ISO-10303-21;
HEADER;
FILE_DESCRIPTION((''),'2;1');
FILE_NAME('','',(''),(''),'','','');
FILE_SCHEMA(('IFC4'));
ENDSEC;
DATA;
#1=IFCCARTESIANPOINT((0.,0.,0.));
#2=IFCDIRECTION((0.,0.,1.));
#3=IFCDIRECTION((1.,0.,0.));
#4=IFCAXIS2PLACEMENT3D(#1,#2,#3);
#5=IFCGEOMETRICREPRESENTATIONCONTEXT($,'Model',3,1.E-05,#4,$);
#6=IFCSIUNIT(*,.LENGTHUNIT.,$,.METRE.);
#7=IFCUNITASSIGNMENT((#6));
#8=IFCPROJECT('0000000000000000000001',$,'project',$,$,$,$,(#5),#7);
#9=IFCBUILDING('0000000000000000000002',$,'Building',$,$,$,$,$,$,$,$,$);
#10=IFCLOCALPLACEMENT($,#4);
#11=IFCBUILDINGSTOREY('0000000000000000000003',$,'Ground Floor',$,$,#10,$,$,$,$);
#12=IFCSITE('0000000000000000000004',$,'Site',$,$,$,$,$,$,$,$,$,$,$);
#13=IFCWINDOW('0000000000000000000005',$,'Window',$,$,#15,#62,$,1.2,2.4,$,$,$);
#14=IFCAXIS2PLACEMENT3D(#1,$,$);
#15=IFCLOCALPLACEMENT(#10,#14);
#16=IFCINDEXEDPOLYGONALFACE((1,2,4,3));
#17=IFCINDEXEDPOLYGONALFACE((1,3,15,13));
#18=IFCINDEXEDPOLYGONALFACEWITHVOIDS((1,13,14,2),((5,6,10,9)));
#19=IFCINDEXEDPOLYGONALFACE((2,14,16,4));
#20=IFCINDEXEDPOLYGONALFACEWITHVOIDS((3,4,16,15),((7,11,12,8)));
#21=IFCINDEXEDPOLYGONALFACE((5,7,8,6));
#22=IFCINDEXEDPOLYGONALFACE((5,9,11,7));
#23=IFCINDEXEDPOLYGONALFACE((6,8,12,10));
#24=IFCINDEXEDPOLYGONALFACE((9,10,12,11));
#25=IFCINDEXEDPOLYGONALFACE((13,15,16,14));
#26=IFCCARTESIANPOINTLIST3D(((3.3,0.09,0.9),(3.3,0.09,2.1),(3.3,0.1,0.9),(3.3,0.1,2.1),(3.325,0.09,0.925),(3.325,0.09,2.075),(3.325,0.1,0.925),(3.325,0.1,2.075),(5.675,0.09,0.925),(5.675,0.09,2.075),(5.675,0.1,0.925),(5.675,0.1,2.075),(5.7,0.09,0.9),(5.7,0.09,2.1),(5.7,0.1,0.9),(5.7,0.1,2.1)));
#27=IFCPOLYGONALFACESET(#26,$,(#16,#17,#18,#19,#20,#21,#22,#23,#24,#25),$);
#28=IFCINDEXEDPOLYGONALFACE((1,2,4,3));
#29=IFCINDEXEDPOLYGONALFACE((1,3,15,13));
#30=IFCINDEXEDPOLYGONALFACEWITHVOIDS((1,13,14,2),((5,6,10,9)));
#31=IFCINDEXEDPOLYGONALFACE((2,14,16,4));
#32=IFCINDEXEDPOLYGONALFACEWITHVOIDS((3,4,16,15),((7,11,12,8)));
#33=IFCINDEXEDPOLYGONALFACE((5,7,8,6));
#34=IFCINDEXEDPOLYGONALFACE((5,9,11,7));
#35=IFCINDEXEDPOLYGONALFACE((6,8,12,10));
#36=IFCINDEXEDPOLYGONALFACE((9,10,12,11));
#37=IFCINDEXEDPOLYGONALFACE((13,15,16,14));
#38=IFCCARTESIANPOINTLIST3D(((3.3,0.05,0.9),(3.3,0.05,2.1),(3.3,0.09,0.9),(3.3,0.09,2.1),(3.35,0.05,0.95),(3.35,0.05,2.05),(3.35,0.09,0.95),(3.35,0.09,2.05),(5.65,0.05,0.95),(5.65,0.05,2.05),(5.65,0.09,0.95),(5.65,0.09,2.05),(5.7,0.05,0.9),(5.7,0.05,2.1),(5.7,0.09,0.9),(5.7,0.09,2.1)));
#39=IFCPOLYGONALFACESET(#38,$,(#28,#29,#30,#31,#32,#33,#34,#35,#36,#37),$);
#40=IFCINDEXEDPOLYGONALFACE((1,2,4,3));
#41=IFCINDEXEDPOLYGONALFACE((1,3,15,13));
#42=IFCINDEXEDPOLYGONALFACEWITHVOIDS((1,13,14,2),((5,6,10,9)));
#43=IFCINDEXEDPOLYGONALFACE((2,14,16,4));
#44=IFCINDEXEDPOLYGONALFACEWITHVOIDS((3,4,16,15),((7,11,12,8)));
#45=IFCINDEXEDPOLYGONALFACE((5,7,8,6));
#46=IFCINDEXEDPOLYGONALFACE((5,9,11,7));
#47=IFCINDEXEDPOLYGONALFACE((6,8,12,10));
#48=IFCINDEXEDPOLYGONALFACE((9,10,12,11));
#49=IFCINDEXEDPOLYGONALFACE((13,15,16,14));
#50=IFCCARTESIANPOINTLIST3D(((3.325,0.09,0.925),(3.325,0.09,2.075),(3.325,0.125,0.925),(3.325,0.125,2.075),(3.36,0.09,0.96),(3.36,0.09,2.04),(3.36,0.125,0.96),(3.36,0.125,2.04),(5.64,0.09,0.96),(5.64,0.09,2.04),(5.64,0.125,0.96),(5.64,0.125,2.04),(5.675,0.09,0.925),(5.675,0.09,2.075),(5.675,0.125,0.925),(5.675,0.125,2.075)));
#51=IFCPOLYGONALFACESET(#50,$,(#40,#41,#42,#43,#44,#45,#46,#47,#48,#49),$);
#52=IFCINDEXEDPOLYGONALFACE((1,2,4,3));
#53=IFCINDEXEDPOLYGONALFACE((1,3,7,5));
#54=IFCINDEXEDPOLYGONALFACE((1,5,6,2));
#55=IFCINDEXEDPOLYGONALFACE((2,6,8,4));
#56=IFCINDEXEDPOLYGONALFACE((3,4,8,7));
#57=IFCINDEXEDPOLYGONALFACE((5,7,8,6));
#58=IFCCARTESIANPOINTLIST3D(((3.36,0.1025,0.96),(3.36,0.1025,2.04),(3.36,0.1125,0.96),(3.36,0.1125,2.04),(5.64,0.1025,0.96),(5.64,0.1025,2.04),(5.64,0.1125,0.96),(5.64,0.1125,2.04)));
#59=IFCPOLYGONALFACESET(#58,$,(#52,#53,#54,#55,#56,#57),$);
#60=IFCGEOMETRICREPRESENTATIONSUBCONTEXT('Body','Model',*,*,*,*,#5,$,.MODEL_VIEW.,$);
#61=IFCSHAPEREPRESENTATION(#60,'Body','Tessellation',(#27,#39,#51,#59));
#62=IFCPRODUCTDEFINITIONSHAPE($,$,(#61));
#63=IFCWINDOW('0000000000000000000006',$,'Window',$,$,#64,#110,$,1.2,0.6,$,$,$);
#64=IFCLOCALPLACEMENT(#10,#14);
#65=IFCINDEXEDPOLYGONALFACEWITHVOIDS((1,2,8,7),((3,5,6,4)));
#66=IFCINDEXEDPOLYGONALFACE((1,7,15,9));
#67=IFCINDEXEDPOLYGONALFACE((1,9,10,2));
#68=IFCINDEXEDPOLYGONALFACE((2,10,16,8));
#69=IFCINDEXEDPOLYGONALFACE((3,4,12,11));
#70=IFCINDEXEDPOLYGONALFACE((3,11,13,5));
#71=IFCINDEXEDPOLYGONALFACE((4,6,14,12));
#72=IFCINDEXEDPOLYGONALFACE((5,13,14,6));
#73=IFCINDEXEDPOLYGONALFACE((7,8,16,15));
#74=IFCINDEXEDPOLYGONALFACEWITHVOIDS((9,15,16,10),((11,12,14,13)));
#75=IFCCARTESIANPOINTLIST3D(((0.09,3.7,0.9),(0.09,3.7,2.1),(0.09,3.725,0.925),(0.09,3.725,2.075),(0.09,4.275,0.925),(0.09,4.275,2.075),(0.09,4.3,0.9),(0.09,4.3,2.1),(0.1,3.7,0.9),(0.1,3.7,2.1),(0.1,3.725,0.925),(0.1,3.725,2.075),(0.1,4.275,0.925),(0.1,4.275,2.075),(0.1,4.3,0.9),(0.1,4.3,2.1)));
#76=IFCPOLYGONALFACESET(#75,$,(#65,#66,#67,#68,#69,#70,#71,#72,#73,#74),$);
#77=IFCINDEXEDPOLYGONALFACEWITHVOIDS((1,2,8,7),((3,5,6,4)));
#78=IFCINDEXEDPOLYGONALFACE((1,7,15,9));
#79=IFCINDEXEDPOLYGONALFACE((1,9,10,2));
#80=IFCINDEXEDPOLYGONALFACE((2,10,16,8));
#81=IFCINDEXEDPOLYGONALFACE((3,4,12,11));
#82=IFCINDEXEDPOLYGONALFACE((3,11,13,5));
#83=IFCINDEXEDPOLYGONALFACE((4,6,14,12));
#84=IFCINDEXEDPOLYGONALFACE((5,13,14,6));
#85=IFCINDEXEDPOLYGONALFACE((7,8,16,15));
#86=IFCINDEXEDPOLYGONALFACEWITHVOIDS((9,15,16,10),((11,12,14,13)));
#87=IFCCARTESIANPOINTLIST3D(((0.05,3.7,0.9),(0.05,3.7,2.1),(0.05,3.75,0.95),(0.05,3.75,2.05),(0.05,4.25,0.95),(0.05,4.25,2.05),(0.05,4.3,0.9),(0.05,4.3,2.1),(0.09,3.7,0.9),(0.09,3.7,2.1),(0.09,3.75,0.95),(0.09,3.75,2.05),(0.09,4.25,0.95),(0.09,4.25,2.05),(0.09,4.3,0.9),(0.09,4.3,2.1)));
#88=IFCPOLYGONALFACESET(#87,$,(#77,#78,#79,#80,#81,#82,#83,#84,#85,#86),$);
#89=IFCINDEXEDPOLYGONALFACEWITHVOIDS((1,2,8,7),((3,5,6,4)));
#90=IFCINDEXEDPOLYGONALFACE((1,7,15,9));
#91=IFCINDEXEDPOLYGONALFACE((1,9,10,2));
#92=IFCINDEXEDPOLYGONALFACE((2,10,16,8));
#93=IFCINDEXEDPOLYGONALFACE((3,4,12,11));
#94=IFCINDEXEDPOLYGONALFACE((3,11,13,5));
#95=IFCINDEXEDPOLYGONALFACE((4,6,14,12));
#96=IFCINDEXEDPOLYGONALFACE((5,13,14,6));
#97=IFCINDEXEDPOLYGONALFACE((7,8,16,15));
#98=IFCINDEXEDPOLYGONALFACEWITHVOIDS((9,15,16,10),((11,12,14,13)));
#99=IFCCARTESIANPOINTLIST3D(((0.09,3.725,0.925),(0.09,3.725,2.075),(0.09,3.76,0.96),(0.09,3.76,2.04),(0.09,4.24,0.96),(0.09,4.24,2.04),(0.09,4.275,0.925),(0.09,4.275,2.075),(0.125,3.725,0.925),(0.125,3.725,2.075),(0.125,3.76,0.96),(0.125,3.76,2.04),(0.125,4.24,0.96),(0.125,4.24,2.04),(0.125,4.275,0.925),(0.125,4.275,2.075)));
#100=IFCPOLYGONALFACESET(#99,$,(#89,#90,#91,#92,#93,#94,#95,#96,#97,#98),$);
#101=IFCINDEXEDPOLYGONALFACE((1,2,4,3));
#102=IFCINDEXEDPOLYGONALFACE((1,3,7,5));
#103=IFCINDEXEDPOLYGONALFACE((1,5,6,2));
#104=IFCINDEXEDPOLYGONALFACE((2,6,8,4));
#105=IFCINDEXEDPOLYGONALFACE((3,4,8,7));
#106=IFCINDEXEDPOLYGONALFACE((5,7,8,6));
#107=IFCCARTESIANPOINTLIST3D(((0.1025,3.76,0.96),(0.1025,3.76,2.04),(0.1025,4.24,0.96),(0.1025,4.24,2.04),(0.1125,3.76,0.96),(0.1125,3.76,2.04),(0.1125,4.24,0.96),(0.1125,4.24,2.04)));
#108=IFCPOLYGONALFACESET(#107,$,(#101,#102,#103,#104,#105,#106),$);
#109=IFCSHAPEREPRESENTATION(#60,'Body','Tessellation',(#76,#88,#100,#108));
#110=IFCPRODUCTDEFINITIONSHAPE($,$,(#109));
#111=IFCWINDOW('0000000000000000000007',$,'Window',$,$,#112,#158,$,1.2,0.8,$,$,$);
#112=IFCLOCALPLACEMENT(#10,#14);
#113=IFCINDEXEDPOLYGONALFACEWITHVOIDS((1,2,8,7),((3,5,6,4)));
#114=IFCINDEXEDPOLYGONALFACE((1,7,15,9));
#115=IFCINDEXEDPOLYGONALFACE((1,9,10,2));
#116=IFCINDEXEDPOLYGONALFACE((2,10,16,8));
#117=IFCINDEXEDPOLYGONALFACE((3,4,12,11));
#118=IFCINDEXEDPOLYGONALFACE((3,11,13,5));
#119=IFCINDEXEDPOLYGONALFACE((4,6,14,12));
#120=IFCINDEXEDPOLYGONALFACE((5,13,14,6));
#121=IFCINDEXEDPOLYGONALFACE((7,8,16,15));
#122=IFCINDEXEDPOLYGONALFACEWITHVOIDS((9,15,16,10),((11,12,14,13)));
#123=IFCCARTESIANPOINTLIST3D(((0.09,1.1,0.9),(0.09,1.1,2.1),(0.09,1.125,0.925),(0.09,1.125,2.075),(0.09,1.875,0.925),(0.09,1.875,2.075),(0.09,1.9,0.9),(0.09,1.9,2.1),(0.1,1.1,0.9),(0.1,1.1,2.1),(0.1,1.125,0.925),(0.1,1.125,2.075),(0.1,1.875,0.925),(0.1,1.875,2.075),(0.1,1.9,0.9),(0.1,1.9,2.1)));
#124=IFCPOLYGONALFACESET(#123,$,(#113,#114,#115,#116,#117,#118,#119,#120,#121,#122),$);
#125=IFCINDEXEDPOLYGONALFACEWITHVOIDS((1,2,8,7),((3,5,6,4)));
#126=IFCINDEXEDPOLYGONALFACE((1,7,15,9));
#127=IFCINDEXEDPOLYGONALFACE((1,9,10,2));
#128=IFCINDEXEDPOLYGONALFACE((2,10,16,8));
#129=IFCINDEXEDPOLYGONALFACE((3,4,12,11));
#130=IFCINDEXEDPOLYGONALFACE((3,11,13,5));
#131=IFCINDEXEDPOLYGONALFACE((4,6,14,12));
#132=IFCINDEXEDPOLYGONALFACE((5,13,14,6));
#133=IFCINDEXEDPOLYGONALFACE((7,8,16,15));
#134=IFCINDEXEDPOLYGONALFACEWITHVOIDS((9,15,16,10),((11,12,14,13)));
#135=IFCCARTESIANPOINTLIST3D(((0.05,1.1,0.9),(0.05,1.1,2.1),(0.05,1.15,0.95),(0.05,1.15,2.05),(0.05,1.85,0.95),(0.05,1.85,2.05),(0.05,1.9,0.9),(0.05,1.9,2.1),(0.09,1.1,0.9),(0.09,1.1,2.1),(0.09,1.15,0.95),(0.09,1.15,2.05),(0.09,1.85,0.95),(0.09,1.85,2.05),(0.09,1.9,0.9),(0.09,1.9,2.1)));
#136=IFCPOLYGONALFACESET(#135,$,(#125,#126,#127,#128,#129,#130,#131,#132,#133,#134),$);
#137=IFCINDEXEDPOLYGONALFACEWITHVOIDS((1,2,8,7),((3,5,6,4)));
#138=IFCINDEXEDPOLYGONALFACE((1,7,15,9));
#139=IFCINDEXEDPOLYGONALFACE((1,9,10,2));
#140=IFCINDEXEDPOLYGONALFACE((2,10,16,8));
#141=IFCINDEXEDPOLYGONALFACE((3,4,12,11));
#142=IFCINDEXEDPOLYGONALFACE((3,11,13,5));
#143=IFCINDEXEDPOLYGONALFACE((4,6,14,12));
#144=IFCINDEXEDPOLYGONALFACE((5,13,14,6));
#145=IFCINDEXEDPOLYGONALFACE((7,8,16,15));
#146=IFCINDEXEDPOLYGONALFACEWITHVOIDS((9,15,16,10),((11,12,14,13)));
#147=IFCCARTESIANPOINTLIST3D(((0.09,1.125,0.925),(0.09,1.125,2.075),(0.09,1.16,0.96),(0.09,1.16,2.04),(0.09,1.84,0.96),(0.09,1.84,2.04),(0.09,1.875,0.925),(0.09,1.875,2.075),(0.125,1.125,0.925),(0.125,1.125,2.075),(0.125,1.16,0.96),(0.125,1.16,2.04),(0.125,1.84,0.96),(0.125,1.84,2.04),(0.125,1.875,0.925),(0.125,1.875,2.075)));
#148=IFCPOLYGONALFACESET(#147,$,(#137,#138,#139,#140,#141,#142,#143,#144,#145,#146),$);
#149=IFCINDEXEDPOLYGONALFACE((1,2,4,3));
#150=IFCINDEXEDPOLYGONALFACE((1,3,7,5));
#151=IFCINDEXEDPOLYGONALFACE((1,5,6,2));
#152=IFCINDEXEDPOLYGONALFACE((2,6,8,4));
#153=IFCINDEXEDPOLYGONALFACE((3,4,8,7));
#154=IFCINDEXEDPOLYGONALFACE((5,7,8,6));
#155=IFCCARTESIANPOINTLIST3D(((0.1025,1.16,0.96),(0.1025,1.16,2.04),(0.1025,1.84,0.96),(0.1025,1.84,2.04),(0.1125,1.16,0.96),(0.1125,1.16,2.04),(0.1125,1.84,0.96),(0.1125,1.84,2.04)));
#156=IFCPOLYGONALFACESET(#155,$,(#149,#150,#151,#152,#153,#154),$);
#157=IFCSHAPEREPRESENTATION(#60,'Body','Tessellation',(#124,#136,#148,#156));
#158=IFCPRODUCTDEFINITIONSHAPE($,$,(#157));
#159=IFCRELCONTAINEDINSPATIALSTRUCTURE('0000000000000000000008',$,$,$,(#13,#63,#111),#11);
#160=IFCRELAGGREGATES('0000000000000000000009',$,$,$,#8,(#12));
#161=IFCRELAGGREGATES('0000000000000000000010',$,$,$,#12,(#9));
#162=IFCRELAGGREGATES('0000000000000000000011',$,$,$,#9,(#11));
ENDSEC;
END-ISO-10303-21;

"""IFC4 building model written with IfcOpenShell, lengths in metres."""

from ifc_helpers import new_model, si_unit, frame, origin_with_axes, place, context, subcontext, project, spatial, line, indexed_curve, outline, extrude, element, save


model = new_model("IFC4")

# Units and contexts
model_context = context("Model", 3, precision=1e-05, world=origin_with_axes())
body_context = subcontext(model_context, "Body", "Model", "MODEL_VIEW")
ifc_project = project(units=[si_unit("LENGTHUNIT", "METRE")], contexts=[model_context])

# Site, building, storey
site = spatial("IfcSite", under=ifc_project, Name="Site")
building = spatial("IfcBuilding", under=site, Name="Building")
storey_placement = place(None, origin_with_axes())
storey = spatial("IfcBuildingStorey", under=building, at=storey_placement, Name="Ground Floor")

# Windows
window_1_placement = place(storey_placement, frame((3.3, 0.0, 0.9), z_axis=(0.0, 0.0, 1.0), x_axis=(1.0, 0.0, 0.0)))
element("IfcWindow", 1, at=window_1_placement, inside=storey, Name="Window", OverallHeight=1.2, OverallWidth=2.4, context=body_context, shape_type="SweptSolid", body=[
    extrude(outline(indexed_curve([(0.0, 0.0), (2.4, 0.0), (2.4, 1.2), (0.0, 1.2)], segments=[line(1, 2, 3, 4, 1)]), holes=[indexed_curve([(0.025, 0.025), (2.375, 0.025), (2.375, 1.175), (0.025, 1.175)], segments=[line(1, 2, 3, 4, 1)])]), frame((0.0, 0.09, 0.0), z_axis=(0.0, -1.0, 0.0), x_axis=(1.0, 0.0, 0.0)), (0.0, 0.0, -1.0), 0.01),
    extrude(outline(indexed_curve([(0.0, 0.0), (2.4, 0.0), (2.4, 1.2), (0.0, 1.2)], segments=[line(1, 2, 3, 4, 1)]), holes=[indexed_curve([(0.05, 0.05), (2.35, 0.05), (2.35, 1.15), (0.05, 1.15)], segments=[line(1, 2, 3, 4, 1)])]), frame((0.0, 0.05, 0.0), z_axis=(0.0, -1.0, 0.0), x_axis=(1.0, 0.0, 0.0)), (0.0, 0.0, -1.0), 0.04),
    extrude(outline(indexed_curve([(0.0, 0.0), (2.35, 0.0), (2.35, 1.15), (0.0, 1.15)], segments=[line(1, 2, 3, 4, 1)]), holes=[indexed_curve([(0.035, 0.035), (2.315, 0.035), (2.315, 1.115), (0.035, 1.115)], segments=[line(1, 2, 3, 4, 1)])]), frame((0.025, 0.09, 0.025), z_axis=(0.0, -1.0, 0.0), x_axis=(1.0, 0.0, 0.0)), (0.0, 0.0, -1.0), 0.035),
    extrude(outline(indexed_curve([(0.035, 0.035), (2.315, 0.035), (2.315, 1.115), (0.035, 1.115)], segments=[line(1, 2, 3, 4, 1)])), frame((0.025, 0.1025, 0.025), z_axis=(0.0, -1.0, 0.0), x_axis=(1.0, 0.0, 0.0)), (0.0, 0.0, -1.0), 0.01),
])
window_2_placement = place(storey_placement, frame((0.0, 4.3, 0.9), z_axis=(0.0, 0.0, 1.0), x_axis=(0.0, -1.0, 0.0)))
element("IfcWindow", 2, at=window_2_placement, inside=storey, Name="Window", OverallHeight=1.2, OverallWidth=0.6, context=body_context, shape_type="SweptSolid", body=[
    extrude(outline(indexed_curve([(0.0, 0.0), (0.6, 0.0), (0.6, 1.2), (0.0, 1.2)], segments=[line(1, 2, 3, 4, 1)]), holes=[indexed_curve([(0.025, 0.025), (0.575, 0.025), (0.575, 1.175), (0.025, 1.175)], segments=[line(1, 2, 3, 4, 1)])]), frame((0.0, 0.09, 0.0), z_axis=(0.0, -1.0, 0.0), x_axis=(1.0, 0.0, 0.0)), (0.0, 0.0, -1.0), 0.01),
    extrude(outline(indexed_curve([(0.0, 0.0), (0.6, 0.0), (0.6, 1.2), (0.0, 1.2)], segments=[line(1, 2, 3, 4, 1)]), holes=[indexed_curve([(0.05, 0.05), (0.55, 0.05), (0.55, 1.15), (0.05, 1.15)], segments=[line(1, 2, 3, 4, 1)])]), frame((0.0, 0.05, 0.0), z_axis=(0.0, -1.0, 0.0), x_axis=(1.0, 0.0, 0.0)), (0.0, 0.0, -1.0), 0.04),
    extrude(outline(indexed_curve([(0.0, 0.0), (0.55, 0.0), (0.55, 1.15), (0.0, 1.15)], segments=[line(1, 2, 3, 4, 1)]), holes=[indexed_curve([(0.035, 0.035), (0.515, 0.035), (0.515, 1.115), (0.035, 1.115)], segments=[line(1, 2, 3, 4, 1)])]), frame((0.025, 0.09, 0.025), z_axis=(0.0, -1.0, 0.0), x_axis=(1.0, 0.0, 0.0)), (0.0, 0.0, -1.0), 0.035),
    extrude(outline(indexed_curve([(0.035, 0.035), (0.515, 0.035), (0.515, 1.115), (0.035, 1.115)], segments=[line(1, 2, 3, 4, 1)])), frame((0.025, 0.1025, 0.025), z_axis=(0.0, -1.0, 0.0), x_axis=(1.0, 0.0, 0.0)), (0.0, 0.0, -1.0), 0.01),
])
window_3_placement = place(storey_placement, frame((0.0, 1.9, 0.9), z_axis=(0.0, 0.0, 1.0), x_axis=(0.0, -1.0, 0.0)))
element("IfcWindow", 3, at=window_3_placement, inside=storey, Name="Window", OverallHeight=1.2, OverallWidth=0.8, context=body_context, shape_type="SweptSolid", body=[
    extrude(outline(indexed_curve([(0.0, 0.0), (0.8, 0.0), (0.8, 1.2), (0.0, 1.2)], segments=[line(1, 2, 3, 4, 1)]), holes=[indexed_curve([(0.025, 0.025), (0.775, 0.025), (0.775, 1.175), (0.025, 1.175)], segments=[line(1, 2, 3, 4, 1)])]), frame((0.0, 0.09, 0.0), z_axis=(0.0, -1.0, 0.0), x_axis=(1.0, 0.0, 0.0)), (0.0, 0.0, -1.0), 0.01),
    extrude(outline(indexed_curve([(0.0, 0.0), (0.8, 0.0), (0.8, 1.2), (0.0, 1.2)], segments=[line(1, 2, 3, 4, 1)]), holes=[indexed_curve([(0.05, 0.05), (0.75, 0.05), (0.75, 1.15), (0.05, 1.15)], segments=[line(1, 2, 3, 4, 1)])]), frame((0.0, 0.05, 0.0), z_axis=(0.0, -1.0, 0.0), x_axis=(1.0, 0.0, 0.0)), (0.0, 0.0, -1.0), 0.04),
    extrude(outline(indexed_curve([(0.0, 0.0), (0.75, 0.0), (0.75, 1.15), (0.0, 1.15)], segments=[line(1, 2, 3, 4, 1)]), holes=[indexed_curve([(0.035, 0.035), (0.715, 0.035), (0.715, 1.115), (0.035, 1.115)], segments=[line(1, 2, 3, 4, 1)])]), frame((0.025, 0.09, 0.025), z_axis=(0.0, -1.0, 0.0), x_axis=(1.0, 0.0, 0.0)), (0.0, 0.0, -1.0), 0.035),
    extrude(outline(indexed_curve([(0.035, 0.035), (0.715, 0.035), (0.715, 1.115), (0.035, 1.115)], segments=[line(1, 2, 3, 4, 1)])), frame((0.025, 0.1025, 0.025), z_axis=(0.0, -1.0, 0.0), x_axis=(1.0, 0.0, 0.0)), (0.0, 0.0, -1.0), 0.01),
])

save(model, "model.ifc")
